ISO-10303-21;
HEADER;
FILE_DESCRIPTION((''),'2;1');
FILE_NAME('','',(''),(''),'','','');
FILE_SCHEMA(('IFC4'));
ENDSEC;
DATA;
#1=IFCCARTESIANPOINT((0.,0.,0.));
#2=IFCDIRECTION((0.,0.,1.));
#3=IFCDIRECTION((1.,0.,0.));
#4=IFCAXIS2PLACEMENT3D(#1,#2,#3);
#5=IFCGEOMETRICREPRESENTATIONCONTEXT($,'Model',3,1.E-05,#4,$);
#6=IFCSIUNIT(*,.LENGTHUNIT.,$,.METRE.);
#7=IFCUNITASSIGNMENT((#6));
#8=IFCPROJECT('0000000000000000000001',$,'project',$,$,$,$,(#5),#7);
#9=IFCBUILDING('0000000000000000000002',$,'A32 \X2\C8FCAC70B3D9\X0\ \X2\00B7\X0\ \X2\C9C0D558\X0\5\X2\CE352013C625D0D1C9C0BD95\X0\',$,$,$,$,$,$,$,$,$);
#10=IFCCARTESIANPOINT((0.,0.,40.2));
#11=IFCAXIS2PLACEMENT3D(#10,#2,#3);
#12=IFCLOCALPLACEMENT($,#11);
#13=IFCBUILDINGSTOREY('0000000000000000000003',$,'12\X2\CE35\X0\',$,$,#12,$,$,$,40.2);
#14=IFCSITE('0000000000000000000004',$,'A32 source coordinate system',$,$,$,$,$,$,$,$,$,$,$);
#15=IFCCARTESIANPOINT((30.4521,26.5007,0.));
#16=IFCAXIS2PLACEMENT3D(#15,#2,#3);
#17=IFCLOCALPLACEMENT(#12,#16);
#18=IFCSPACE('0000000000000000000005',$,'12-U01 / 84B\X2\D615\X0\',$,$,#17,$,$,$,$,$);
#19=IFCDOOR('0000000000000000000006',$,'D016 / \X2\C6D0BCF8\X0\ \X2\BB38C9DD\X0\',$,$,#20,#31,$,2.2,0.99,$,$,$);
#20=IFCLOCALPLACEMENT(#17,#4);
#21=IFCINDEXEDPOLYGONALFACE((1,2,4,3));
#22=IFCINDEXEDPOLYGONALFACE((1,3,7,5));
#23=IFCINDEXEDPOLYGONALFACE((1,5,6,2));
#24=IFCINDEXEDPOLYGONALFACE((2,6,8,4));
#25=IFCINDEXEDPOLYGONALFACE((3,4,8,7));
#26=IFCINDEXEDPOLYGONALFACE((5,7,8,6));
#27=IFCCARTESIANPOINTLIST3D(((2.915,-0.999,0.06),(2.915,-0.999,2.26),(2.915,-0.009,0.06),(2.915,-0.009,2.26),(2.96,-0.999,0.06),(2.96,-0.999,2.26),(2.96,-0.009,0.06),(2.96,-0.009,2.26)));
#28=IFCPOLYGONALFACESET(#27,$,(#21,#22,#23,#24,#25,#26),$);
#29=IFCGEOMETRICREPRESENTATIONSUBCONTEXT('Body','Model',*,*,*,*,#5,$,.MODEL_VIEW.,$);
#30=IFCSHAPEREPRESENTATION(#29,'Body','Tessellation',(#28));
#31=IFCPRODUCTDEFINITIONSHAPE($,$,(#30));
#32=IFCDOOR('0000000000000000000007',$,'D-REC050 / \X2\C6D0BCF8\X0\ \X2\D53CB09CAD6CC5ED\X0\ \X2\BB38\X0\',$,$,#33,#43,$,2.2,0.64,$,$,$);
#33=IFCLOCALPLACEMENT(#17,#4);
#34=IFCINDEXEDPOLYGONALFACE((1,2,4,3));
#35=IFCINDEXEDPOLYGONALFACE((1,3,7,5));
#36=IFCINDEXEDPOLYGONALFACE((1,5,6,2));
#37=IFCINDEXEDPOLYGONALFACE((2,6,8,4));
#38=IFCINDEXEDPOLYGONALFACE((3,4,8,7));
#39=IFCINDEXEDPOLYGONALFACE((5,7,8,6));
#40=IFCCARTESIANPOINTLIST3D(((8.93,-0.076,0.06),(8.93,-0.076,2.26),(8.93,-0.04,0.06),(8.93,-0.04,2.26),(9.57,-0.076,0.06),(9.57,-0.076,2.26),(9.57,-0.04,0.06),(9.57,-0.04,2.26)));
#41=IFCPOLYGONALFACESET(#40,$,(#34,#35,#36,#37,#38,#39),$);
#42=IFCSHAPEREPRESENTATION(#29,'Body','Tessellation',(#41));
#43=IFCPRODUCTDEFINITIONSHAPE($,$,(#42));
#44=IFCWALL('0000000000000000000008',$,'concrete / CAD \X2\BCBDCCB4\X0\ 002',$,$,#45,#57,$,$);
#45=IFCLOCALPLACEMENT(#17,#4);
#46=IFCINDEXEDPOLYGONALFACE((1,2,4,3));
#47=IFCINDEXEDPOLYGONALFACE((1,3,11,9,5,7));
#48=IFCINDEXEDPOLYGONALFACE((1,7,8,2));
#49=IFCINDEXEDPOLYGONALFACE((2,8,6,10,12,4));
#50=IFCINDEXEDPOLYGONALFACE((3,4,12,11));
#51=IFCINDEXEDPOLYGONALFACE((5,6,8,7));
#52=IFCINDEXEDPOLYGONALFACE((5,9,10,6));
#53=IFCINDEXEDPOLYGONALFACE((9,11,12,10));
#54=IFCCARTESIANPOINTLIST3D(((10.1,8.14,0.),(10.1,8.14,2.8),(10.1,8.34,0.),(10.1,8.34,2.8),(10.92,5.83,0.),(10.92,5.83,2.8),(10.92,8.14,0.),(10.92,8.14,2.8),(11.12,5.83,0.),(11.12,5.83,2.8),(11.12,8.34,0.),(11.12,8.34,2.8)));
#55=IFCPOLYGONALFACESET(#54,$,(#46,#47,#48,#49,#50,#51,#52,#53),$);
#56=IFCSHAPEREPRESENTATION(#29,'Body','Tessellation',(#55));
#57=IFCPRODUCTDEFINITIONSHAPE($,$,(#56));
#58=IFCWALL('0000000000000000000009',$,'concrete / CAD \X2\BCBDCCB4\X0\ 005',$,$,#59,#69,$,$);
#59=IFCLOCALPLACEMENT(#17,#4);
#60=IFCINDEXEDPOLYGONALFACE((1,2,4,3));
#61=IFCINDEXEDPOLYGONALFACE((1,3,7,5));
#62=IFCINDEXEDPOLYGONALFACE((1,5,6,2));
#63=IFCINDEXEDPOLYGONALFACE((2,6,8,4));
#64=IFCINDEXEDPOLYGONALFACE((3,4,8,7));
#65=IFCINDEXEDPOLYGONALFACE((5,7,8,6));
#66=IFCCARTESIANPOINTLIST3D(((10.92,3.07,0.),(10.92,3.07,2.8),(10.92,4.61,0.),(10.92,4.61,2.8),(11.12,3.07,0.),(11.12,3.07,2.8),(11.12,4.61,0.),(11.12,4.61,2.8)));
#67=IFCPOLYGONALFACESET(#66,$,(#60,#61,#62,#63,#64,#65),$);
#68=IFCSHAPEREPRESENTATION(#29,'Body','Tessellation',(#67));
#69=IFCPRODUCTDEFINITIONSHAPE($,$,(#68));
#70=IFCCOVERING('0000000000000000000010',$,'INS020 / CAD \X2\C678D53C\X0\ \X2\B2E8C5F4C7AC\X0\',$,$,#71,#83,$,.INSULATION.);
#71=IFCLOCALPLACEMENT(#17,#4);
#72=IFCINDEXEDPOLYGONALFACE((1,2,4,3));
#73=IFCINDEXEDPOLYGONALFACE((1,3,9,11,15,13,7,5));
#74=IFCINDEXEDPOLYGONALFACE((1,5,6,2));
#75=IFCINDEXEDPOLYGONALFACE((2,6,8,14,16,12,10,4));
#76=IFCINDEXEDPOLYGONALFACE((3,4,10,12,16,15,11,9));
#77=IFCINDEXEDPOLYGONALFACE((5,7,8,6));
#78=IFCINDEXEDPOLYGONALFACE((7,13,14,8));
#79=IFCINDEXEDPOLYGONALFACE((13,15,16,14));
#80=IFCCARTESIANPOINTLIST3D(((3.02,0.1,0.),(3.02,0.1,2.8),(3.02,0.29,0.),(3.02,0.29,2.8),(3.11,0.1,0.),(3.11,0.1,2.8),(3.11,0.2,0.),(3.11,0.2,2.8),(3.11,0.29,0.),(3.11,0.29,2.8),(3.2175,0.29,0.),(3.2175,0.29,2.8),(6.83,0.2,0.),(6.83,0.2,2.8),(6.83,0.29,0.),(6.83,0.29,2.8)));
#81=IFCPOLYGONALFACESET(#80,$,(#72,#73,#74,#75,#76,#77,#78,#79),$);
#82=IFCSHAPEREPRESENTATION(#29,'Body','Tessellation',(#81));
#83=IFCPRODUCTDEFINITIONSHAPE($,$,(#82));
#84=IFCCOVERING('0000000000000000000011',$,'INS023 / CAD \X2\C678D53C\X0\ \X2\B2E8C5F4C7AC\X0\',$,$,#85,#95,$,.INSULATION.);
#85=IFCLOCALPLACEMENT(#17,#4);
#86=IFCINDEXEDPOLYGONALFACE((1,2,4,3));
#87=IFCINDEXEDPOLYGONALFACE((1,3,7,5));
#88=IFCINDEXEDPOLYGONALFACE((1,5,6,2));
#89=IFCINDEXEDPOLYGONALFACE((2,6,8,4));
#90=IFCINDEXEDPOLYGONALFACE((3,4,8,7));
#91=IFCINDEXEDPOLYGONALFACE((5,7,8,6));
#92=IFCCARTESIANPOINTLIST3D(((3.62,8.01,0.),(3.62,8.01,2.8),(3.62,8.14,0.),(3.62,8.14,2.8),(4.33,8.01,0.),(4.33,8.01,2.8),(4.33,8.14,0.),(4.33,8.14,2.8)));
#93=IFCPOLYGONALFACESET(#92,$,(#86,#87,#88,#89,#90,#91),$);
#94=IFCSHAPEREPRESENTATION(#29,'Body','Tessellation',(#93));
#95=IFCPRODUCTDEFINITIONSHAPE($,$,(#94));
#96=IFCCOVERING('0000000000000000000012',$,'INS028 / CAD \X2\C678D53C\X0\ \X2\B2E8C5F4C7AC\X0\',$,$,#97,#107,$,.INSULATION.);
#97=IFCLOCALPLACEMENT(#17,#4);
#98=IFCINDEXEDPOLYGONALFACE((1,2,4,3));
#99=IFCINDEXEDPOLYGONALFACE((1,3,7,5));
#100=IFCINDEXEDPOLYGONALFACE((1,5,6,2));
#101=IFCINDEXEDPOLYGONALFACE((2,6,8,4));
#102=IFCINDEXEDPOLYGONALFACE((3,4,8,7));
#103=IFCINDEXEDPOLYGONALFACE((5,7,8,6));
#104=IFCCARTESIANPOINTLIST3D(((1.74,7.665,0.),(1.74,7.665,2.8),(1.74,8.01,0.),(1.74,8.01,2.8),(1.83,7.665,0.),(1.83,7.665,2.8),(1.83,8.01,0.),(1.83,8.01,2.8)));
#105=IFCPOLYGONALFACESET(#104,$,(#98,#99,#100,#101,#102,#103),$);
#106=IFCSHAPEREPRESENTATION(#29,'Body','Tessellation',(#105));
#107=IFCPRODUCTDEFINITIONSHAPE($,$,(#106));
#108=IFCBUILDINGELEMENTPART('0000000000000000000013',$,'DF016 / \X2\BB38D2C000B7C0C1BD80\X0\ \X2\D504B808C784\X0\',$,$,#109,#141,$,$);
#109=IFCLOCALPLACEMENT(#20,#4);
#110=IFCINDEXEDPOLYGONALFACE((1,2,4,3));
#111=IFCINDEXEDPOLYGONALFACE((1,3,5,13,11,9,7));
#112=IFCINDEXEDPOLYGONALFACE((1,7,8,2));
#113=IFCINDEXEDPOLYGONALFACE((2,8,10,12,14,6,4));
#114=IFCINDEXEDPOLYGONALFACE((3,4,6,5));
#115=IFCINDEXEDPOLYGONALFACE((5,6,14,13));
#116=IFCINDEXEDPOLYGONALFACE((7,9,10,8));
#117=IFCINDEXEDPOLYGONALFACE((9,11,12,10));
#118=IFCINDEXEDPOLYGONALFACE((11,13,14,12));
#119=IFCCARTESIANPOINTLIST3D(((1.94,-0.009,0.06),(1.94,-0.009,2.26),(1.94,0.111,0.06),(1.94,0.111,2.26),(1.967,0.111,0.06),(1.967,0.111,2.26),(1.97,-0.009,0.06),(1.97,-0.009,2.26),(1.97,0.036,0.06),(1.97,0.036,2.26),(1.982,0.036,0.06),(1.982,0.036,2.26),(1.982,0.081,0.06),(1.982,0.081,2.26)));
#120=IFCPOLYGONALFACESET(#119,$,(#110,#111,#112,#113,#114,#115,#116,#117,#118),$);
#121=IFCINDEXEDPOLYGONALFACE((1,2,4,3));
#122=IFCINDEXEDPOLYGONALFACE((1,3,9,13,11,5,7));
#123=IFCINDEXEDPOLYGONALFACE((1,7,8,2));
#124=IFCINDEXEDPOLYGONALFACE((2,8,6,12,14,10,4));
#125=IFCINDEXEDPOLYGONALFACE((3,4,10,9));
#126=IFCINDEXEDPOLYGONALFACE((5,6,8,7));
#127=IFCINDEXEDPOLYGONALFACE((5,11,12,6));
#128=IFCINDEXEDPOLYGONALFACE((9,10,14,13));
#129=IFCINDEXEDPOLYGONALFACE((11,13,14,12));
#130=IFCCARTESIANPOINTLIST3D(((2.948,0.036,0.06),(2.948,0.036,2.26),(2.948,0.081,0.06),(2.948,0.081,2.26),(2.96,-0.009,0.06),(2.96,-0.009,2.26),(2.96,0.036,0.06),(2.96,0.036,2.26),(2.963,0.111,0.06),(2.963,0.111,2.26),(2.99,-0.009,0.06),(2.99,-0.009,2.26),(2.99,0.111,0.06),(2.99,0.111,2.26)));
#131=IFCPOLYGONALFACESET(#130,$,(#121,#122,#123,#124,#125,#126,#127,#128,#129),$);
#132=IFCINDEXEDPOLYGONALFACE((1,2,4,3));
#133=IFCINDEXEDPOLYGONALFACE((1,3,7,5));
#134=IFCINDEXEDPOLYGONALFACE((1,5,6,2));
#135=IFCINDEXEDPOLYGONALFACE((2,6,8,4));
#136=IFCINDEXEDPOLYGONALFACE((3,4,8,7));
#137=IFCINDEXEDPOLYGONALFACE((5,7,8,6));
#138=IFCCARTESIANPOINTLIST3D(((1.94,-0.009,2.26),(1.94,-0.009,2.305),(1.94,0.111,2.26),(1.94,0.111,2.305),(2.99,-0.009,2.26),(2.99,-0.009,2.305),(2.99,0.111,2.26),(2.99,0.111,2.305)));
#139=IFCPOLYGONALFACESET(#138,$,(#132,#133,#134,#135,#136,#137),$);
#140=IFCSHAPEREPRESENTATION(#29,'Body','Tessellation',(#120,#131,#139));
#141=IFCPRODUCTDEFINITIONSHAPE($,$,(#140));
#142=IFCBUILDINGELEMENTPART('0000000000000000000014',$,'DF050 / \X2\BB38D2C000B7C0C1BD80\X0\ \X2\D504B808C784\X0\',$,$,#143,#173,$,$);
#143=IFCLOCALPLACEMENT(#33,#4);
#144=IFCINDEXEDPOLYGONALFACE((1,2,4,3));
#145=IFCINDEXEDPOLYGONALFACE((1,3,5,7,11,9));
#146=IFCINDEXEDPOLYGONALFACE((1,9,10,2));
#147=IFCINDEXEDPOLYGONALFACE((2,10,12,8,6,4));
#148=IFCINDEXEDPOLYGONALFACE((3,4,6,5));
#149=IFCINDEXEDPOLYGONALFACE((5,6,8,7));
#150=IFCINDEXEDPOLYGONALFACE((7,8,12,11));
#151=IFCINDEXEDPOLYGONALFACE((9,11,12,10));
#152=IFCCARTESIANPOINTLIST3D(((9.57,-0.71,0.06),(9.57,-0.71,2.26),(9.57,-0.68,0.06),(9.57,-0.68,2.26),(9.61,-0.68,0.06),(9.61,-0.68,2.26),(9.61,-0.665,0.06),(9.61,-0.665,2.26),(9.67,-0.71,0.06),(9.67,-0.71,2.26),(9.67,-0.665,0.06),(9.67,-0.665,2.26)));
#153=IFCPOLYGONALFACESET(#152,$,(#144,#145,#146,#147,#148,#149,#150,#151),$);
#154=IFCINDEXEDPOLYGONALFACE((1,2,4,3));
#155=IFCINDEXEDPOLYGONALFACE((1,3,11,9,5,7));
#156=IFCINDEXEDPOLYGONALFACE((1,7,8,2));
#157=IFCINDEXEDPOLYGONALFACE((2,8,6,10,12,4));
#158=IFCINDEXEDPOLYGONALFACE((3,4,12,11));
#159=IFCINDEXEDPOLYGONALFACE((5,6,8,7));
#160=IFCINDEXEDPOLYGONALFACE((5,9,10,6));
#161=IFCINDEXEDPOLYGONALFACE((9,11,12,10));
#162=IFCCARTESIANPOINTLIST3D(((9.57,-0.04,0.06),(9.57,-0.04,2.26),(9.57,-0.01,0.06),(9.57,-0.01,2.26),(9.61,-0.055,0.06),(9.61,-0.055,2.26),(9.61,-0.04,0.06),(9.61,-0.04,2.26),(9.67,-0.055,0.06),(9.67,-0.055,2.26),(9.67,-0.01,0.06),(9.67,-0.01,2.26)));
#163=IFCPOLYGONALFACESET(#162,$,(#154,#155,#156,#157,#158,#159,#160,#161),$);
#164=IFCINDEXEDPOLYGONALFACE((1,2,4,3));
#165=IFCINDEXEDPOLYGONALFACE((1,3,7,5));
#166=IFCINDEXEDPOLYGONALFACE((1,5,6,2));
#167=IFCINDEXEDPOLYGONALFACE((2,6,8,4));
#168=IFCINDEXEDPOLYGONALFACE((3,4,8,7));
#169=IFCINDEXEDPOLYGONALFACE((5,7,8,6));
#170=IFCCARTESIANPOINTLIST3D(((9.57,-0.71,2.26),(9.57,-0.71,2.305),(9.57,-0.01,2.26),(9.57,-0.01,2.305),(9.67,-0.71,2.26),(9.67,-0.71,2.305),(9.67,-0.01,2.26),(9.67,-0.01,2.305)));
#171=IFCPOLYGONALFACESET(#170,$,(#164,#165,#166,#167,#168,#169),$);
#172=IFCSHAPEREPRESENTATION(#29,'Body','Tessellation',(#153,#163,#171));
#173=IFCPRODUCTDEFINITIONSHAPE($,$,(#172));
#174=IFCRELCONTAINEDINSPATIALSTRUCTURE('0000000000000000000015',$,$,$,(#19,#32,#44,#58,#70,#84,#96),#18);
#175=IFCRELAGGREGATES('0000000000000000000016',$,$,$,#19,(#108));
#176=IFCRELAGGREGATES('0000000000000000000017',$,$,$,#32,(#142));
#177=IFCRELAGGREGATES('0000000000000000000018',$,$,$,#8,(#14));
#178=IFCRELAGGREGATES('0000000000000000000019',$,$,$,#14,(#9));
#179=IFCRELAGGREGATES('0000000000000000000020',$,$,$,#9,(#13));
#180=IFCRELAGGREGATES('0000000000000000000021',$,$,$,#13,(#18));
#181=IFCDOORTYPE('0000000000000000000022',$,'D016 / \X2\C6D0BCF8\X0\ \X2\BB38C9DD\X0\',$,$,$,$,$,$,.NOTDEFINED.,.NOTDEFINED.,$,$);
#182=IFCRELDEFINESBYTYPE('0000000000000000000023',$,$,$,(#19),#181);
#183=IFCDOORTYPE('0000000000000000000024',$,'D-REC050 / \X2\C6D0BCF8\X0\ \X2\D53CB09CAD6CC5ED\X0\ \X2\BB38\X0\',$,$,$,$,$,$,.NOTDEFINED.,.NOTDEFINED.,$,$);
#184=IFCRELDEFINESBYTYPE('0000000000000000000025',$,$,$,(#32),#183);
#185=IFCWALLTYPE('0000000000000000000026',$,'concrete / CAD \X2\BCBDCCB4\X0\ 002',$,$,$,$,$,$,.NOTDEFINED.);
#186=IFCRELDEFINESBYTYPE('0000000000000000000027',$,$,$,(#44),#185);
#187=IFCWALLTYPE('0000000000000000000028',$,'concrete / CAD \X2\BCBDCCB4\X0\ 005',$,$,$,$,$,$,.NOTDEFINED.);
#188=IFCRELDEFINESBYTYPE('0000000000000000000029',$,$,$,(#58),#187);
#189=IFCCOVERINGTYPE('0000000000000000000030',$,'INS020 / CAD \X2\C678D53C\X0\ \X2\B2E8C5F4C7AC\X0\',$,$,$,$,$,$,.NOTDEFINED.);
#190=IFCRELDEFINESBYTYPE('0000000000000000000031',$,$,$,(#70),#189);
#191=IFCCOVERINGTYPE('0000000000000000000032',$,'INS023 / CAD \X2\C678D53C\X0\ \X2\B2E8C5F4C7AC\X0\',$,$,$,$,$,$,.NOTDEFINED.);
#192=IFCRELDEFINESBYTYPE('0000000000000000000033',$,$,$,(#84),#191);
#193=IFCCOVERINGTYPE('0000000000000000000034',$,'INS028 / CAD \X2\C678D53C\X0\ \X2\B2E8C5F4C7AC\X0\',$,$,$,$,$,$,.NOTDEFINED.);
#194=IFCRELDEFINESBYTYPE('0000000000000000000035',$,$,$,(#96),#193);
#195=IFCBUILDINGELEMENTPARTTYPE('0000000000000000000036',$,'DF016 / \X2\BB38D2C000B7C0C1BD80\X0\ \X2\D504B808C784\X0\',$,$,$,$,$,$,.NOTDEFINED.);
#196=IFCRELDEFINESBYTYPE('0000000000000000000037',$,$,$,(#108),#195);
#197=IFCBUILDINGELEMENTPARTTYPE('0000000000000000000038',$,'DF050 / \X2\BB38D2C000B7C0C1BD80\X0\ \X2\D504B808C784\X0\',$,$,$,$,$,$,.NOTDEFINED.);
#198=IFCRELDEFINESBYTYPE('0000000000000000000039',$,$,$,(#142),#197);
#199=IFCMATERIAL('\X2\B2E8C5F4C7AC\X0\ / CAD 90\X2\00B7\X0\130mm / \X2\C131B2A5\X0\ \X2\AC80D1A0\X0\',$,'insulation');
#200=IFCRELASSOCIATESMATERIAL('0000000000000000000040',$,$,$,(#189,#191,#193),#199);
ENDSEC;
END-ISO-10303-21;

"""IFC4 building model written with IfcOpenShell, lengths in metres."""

from ifc_helpers import new_model, si_unit, frame, origin, origin_with_axes, place, context, subcontext, project, spatial, polyline, outline, extrude, source, transform, mapped, material, type_object, type_shapes, element, aggregate, save


model = new_model("IFC4")

# Units and contexts
model_context = context("Model", 3, precision=1e-05, world=origin_with_axes())
body_context = subcontext(model_context, "Body", "Model", "MODEL_VIEW")
ifc_project = project(units=[si_unit("LENGTHUNIT", "METRE")], contexts=[model_context])

# Site, building, storey, space
storey_placement = place(None, frame((0.0, 0.0, 40.2), z_axis=(0.0, 0.0, 1.0), x_axis=(1.0, 0.0, 0.0)))
space_placement = place(storey_placement, frame((30.4521, 26.5007, 0.0), z_axis=(0.0, 0.0, 1.0), x_axis=(1.0, 0.0, 0.0)))
site = spatial("IfcSite", under=ifc_project, Name="A32 source coordinate system")
building = spatial("IfcBuilding", under=site, Name="A32 주거동 · 지하5층–옥탑지붕")
storey = spatial("IfcBuildingStorey", under=building, at=storey_placement, Name="12층", Elevation=40.2)
space = spatial("IfcSpace", under=storey, at=space_placement, Name="12-U01 / 84B형")

# Doors
door_type_1 = type_object("IfcDoorType", Name="D016 / 원본 문짝", OperationType="NOTDEFINED", PredefinedType="NOTDEFINED")
shared_shape_1 = source(origin(), body_context, "Body", "SweptSolid", [
    extrude(outline(polyline([(2.96, -0.009), (2.96, -0.999), (2.915, -0.999), (2.915, -0.009), (2.96, -0.009)])), frame((0.0, 0.0, 0.06)), (0.0, 0.0, 1.0), 2.2),
])
type_shapes(door_type_1, [shared_shape_1])
door_1_placement = place(space_placement, origin_with_axes())
door_1 = element("IfcDoor", 1, at=door_1_placement, inside=space, type_object=door_type_1, Name="D016 / 원본 문짝", OverallHeight=2.2, OverallWidth=0.99, context=body_context, shape_type="MappedRepresentation", body=[
    mapped(shared_shape_1, transform((0.0, 0.0, 0.0), scale=1.0)),
])
door_type_2 = type_object("IfcDoorType", Name="D-REC050 / 원본 피난구역 문", OperationType="NOTDEFINED", PredefinedType="NOTDEFINED")
shared_shape_2 = source(origin(), body_context, "Body", "SweptSolid", [
    extrude(outline(polyline([(9.57, -0.04), (9.57, -0.076), (8.93, -0.076), (8.93, -0.04), (9.57, -0.04)])), frame((0.0, 0.0, 0.06)), (0.0, 0.0, 1.0), 2.2),
])
type_shapes(door_type_2, [shared_shape_2])
door_2_placement = place(space_placement, origin_with_axes())
door_2 = element("IfcDoor", 2, at=door_2_placement, inside=space, type_object=door_type_2, Name="D-REC050 / 원본 피난구역 문", OverallHeight=2.2, OverallWidth=0.64, context=body_context, shape_type="MappedRepresentation", body=[
    mapped(shared_shape_2, transform((0.0, 0.0, 0.0), scale=1.0)),
])

# Walls
wall_type_1 = type_object("IfcWallType", Name="concrete / CAD 벽체 002", PredefinedType="NOTDEFINED")
shared_shape_3 = source(origin(), body_context, "Body", "SweptSolid", [
    extrude(outline(polyline([(11.12, 5.83), (10.92, 5.83), (10.92, 8.14), (10.1, 8.14), (10.1, 8.34), (11.12, 8.34), (11.12, 5.83)])), origin(), (0.0, 0.0, 1.0), 2.8),
])
type_shapes(wall_type_1, [shared_shape_3])
wall_1_placement = place(space_placement, origin_with_axes())
element("IfcWall", 3, at=wall_1_placement, inside=space, type_object=wall_type_1, Name="concrete / CAD 벽체 002", context=body_context, shape_type="MappedRepresentation", body=[
    mapped(shared_shape_3, transform((0.0, 0.0, 0.0), scale=1.0)),
])
wall_type_2 = type_object("IfcWallType", Name="concrete / CAD 벽체 005", PredefinedType="NOTDEFINED")
shared_shape_4 = source(origin(), body_context, "Body", "SweptSolid", [
    extrude(outline(polyline([(11.12, 3.07), (10.92, 3.07), (10.92, 4.61), (11.12, 4.61), (11.12, 3.07)])), origin(), (0.0, 0.0, 1.0), 2.8),
])
type_shapes(wall_type_2, [shared_shape_4])
wall_2_placement = place(space_placement, origin_with_axes())
element("IfcWall", 4, at=wall_2_placement, inside=space, type_object=wall_type_2, Name="concrete / CAD 벽체 005", context=body_context, shape_type="MappedRepresentation", body=[
    mapped(shared_shape_4, transform((0.0, 0.0, 0.0), scale=1.0)),
])

# Coverings
ifc_material = material(Name="단열재 / CAD 90·130mm / 성능 검토", Category="insulation")
covering_type_1 = type_object("IfcCoveringType", Name="INS020 / CAD 외피 단열재", PredefinedType="NOTDEFINED", material=ifc_material)
shared_shape_5 = source(origin(), body_context, "Body", "SweptSolid", [
    extrude(outline(polyline([(3.11, 0.2), (3.11, 0.1), (3.02, 0.1), (3.02, 0.29), (3.11, 0.29), (3.2175, 0.29), (6.83, 0.29), (6.83, 0.2), (3.11, 0.2)])), origin(), (0.0, 0.0, 1.0), 2.8),
])
type_shapes(covering_type_1, [shared_shape_5])
covering_1_placement = place(space_placement, origin_with_axes())
element("IfcCovering", 5, at=covering_1_placement, inside=space, type_object=covering_type_1, Name="INS020 / CAD 외피 단열재", PredefinedType="INSULATION", context=body_context, shape_type="MappedRepresentation", body=[
    mapped(shared_shape_5, transform((0.0, 0.0, 0.0), scale=1.0)),
])
covering_type_2 = type_object("IfcCoveringType", Name="INS023 / CAD 외피 단열재", PredefinedType="NOTDEFINED", material=ifc_material)
shared_shape_6 = source(origin(), body_context, "Body", "SweptSolid", [
    extrude(outline(polyline([(4.33, 8.01), (3.62, 8.01), (3.62, 8.14), (4.33, 8.14), (4.33, 8.01)])), origin(), (0.0, 0.0, 1.0), 2.8),
])
type_shapes(covering_type_2, [shared_shape_6])
covering_2_placement = place(space_placement, origin_with_axes())
element("IfcCovering", 6, at=covering_2_placement, inside=space, type_object=covering_type_2, Name="INS023 / CAD 외피 단열재", PredefinedType="INSULATION", context=body_context, shape_type="MappedRepresentation", body=[
    mapped(shared_shape_6, transform((0.0, 0.0, 0.0), scale=1.0)),
])
covering_type_3 = type_object("IfcCoveringType", Name="INS028 / CAD 외피 단열재", PredefinedType="NOTDEFINED", material=ifc_material)
shared_shape_7 = source(origin(), body_context, "Body", "SweptSolid", [
    extrude(outline(polyline([(1.74, 8.01), (1.83, 8.01), (1.83, 7.665), (1.74, 7.665), (1.74, 8.01)])), origin(), (0.0, 0.0, 1.0), 2.8),
])
type_shapes(covering_type_3, [shared_shape_7])
covering_3_placement = place(space_placement, origin_with_axes())
element("IfcCovering", 7, at=covering_3_placement, inside=space, type_object=covering_type_3, Name="INS028 / CAD 외피 단열재", PredefinedType="INSULATION", context=body_context, shape_type="MappedRepresentation", body=[
    mapped(shared_shape_7, transform((0.0, 0.0, 0.0), scale=1.0)),
])

# Building element parts
building_element_part_type_1 = type_object("IfcBuildingElementPartType", Name="DF016 / 문틀·상부 프레임", PredefinedType="NOTDEFINED")
shared_shape_8 = source(origin(), body_context, "Body", "SweptSolid", [
    extrude(outline(polyline([(1.94, 0.111), (1.967, 0.111), (1.982, 0.081), (1.982, 0.036), (1.97, 0.036), (1.97, -0.009), (1.94, -0.009), (1.94, 0.111)])), frame((0.0, 0.0, 0.06)), (0.0, 0.0, 1.0), 2.2),
    extrude(outline(polyline([(2.96, -0.009), (2.96, 0.036), (2.948, 0.036), (2.948, 0.081), (2.963, 0.111), (2.99, 0.111), (2.99, -0.009), (2.96, -0.009)])), frame((0.0, 0.0, 0.06)), (0.0, 0.0, 1.0), 2.2),
    extrude(outline(polyline([(1.94, -0.009), (1.94, 0.111), (2.99, 0.111), (2.99, -0.009), (1.94, -0.009)])), frame((0.0, 0.0, 2.26)), (0.0, 0.0, 1.0), 0.045),
])
type_shapes(building_element_part_type_1, [shared_shape_8])
building_element_part_1_placement = place(door_1_placement, origin_with_axes())
building_element_part_1 = element("IfcBuildingElementPart", 8, at=building_element_part_1_placement, type_object=building_element_part_type_1, Name="DF016 / 문틀·상부 프레임", context=body_context, shape_type="MappedRepresentation", body=[
    mapped(shared_shape_8, transform((0.0, 0.0, 0.0), scale=1.0)),
])
aggregate(door_1, [building_element_part_1])
building_element_part_type_2 = type_object("IfcBuildingElementPartType", Name="DF050 / 문틀·상부 프레임", PredefinedType="NOTDEFINED")
shared_shape_9 = source(origin(), body_context, "Body", "SweptSolid", [
    extrude(outline(polyline([(9.57, -0.68), (9.61, -0.68), (9.61, -0.665), (9.67, -0.665), (9.67, -0.71), (9.57, -0.71), (9.57, -0.68)])), frame((0.0, 0.0, 0.06)), (0.0, 0.0, 1.0), 2.2),
    extrude(outline(polyline([(9.67, -0.01), (9.67, -0.055), (9.61, -0.055), (9.61, -0.04), (9.57, -0.04), (9.57, -0.01), (9.67, -0.01)])), frame((0.0, 0.0, 0.06)), (0.0, 0.0, 1.0), 2.2),
    extrude(outline(polyline([(9.57, -0.71), (9.57, -0.01), (9.67, -0.01), (9.67, -0.71), (9.57, -0.71)])), frame((0.0, 0.0, 2.26)), (0.0, 0.0, 1.0), 0.045),
])
type_shapes(building_element_part_type_2, [shared_shape_9])
building_element_part_2_placement = place(door_2_placement, origin_with_axes())
building_element_part_2 = element("IfcBuildingElementPart", 9, at=building_element_part_2_placement, type_object=building_element_part_type_2, Name="DF050 / 문틀·상부 프레임", context=body_context, shape_type="MappedRepresentation", body=[
    mapped(shared_shape_9, transform((0.0, 0.0, 0.0), scale=1.0)),
])
aggregate(door_2, [building_element_part_2])

save(model, "model.ifc")
